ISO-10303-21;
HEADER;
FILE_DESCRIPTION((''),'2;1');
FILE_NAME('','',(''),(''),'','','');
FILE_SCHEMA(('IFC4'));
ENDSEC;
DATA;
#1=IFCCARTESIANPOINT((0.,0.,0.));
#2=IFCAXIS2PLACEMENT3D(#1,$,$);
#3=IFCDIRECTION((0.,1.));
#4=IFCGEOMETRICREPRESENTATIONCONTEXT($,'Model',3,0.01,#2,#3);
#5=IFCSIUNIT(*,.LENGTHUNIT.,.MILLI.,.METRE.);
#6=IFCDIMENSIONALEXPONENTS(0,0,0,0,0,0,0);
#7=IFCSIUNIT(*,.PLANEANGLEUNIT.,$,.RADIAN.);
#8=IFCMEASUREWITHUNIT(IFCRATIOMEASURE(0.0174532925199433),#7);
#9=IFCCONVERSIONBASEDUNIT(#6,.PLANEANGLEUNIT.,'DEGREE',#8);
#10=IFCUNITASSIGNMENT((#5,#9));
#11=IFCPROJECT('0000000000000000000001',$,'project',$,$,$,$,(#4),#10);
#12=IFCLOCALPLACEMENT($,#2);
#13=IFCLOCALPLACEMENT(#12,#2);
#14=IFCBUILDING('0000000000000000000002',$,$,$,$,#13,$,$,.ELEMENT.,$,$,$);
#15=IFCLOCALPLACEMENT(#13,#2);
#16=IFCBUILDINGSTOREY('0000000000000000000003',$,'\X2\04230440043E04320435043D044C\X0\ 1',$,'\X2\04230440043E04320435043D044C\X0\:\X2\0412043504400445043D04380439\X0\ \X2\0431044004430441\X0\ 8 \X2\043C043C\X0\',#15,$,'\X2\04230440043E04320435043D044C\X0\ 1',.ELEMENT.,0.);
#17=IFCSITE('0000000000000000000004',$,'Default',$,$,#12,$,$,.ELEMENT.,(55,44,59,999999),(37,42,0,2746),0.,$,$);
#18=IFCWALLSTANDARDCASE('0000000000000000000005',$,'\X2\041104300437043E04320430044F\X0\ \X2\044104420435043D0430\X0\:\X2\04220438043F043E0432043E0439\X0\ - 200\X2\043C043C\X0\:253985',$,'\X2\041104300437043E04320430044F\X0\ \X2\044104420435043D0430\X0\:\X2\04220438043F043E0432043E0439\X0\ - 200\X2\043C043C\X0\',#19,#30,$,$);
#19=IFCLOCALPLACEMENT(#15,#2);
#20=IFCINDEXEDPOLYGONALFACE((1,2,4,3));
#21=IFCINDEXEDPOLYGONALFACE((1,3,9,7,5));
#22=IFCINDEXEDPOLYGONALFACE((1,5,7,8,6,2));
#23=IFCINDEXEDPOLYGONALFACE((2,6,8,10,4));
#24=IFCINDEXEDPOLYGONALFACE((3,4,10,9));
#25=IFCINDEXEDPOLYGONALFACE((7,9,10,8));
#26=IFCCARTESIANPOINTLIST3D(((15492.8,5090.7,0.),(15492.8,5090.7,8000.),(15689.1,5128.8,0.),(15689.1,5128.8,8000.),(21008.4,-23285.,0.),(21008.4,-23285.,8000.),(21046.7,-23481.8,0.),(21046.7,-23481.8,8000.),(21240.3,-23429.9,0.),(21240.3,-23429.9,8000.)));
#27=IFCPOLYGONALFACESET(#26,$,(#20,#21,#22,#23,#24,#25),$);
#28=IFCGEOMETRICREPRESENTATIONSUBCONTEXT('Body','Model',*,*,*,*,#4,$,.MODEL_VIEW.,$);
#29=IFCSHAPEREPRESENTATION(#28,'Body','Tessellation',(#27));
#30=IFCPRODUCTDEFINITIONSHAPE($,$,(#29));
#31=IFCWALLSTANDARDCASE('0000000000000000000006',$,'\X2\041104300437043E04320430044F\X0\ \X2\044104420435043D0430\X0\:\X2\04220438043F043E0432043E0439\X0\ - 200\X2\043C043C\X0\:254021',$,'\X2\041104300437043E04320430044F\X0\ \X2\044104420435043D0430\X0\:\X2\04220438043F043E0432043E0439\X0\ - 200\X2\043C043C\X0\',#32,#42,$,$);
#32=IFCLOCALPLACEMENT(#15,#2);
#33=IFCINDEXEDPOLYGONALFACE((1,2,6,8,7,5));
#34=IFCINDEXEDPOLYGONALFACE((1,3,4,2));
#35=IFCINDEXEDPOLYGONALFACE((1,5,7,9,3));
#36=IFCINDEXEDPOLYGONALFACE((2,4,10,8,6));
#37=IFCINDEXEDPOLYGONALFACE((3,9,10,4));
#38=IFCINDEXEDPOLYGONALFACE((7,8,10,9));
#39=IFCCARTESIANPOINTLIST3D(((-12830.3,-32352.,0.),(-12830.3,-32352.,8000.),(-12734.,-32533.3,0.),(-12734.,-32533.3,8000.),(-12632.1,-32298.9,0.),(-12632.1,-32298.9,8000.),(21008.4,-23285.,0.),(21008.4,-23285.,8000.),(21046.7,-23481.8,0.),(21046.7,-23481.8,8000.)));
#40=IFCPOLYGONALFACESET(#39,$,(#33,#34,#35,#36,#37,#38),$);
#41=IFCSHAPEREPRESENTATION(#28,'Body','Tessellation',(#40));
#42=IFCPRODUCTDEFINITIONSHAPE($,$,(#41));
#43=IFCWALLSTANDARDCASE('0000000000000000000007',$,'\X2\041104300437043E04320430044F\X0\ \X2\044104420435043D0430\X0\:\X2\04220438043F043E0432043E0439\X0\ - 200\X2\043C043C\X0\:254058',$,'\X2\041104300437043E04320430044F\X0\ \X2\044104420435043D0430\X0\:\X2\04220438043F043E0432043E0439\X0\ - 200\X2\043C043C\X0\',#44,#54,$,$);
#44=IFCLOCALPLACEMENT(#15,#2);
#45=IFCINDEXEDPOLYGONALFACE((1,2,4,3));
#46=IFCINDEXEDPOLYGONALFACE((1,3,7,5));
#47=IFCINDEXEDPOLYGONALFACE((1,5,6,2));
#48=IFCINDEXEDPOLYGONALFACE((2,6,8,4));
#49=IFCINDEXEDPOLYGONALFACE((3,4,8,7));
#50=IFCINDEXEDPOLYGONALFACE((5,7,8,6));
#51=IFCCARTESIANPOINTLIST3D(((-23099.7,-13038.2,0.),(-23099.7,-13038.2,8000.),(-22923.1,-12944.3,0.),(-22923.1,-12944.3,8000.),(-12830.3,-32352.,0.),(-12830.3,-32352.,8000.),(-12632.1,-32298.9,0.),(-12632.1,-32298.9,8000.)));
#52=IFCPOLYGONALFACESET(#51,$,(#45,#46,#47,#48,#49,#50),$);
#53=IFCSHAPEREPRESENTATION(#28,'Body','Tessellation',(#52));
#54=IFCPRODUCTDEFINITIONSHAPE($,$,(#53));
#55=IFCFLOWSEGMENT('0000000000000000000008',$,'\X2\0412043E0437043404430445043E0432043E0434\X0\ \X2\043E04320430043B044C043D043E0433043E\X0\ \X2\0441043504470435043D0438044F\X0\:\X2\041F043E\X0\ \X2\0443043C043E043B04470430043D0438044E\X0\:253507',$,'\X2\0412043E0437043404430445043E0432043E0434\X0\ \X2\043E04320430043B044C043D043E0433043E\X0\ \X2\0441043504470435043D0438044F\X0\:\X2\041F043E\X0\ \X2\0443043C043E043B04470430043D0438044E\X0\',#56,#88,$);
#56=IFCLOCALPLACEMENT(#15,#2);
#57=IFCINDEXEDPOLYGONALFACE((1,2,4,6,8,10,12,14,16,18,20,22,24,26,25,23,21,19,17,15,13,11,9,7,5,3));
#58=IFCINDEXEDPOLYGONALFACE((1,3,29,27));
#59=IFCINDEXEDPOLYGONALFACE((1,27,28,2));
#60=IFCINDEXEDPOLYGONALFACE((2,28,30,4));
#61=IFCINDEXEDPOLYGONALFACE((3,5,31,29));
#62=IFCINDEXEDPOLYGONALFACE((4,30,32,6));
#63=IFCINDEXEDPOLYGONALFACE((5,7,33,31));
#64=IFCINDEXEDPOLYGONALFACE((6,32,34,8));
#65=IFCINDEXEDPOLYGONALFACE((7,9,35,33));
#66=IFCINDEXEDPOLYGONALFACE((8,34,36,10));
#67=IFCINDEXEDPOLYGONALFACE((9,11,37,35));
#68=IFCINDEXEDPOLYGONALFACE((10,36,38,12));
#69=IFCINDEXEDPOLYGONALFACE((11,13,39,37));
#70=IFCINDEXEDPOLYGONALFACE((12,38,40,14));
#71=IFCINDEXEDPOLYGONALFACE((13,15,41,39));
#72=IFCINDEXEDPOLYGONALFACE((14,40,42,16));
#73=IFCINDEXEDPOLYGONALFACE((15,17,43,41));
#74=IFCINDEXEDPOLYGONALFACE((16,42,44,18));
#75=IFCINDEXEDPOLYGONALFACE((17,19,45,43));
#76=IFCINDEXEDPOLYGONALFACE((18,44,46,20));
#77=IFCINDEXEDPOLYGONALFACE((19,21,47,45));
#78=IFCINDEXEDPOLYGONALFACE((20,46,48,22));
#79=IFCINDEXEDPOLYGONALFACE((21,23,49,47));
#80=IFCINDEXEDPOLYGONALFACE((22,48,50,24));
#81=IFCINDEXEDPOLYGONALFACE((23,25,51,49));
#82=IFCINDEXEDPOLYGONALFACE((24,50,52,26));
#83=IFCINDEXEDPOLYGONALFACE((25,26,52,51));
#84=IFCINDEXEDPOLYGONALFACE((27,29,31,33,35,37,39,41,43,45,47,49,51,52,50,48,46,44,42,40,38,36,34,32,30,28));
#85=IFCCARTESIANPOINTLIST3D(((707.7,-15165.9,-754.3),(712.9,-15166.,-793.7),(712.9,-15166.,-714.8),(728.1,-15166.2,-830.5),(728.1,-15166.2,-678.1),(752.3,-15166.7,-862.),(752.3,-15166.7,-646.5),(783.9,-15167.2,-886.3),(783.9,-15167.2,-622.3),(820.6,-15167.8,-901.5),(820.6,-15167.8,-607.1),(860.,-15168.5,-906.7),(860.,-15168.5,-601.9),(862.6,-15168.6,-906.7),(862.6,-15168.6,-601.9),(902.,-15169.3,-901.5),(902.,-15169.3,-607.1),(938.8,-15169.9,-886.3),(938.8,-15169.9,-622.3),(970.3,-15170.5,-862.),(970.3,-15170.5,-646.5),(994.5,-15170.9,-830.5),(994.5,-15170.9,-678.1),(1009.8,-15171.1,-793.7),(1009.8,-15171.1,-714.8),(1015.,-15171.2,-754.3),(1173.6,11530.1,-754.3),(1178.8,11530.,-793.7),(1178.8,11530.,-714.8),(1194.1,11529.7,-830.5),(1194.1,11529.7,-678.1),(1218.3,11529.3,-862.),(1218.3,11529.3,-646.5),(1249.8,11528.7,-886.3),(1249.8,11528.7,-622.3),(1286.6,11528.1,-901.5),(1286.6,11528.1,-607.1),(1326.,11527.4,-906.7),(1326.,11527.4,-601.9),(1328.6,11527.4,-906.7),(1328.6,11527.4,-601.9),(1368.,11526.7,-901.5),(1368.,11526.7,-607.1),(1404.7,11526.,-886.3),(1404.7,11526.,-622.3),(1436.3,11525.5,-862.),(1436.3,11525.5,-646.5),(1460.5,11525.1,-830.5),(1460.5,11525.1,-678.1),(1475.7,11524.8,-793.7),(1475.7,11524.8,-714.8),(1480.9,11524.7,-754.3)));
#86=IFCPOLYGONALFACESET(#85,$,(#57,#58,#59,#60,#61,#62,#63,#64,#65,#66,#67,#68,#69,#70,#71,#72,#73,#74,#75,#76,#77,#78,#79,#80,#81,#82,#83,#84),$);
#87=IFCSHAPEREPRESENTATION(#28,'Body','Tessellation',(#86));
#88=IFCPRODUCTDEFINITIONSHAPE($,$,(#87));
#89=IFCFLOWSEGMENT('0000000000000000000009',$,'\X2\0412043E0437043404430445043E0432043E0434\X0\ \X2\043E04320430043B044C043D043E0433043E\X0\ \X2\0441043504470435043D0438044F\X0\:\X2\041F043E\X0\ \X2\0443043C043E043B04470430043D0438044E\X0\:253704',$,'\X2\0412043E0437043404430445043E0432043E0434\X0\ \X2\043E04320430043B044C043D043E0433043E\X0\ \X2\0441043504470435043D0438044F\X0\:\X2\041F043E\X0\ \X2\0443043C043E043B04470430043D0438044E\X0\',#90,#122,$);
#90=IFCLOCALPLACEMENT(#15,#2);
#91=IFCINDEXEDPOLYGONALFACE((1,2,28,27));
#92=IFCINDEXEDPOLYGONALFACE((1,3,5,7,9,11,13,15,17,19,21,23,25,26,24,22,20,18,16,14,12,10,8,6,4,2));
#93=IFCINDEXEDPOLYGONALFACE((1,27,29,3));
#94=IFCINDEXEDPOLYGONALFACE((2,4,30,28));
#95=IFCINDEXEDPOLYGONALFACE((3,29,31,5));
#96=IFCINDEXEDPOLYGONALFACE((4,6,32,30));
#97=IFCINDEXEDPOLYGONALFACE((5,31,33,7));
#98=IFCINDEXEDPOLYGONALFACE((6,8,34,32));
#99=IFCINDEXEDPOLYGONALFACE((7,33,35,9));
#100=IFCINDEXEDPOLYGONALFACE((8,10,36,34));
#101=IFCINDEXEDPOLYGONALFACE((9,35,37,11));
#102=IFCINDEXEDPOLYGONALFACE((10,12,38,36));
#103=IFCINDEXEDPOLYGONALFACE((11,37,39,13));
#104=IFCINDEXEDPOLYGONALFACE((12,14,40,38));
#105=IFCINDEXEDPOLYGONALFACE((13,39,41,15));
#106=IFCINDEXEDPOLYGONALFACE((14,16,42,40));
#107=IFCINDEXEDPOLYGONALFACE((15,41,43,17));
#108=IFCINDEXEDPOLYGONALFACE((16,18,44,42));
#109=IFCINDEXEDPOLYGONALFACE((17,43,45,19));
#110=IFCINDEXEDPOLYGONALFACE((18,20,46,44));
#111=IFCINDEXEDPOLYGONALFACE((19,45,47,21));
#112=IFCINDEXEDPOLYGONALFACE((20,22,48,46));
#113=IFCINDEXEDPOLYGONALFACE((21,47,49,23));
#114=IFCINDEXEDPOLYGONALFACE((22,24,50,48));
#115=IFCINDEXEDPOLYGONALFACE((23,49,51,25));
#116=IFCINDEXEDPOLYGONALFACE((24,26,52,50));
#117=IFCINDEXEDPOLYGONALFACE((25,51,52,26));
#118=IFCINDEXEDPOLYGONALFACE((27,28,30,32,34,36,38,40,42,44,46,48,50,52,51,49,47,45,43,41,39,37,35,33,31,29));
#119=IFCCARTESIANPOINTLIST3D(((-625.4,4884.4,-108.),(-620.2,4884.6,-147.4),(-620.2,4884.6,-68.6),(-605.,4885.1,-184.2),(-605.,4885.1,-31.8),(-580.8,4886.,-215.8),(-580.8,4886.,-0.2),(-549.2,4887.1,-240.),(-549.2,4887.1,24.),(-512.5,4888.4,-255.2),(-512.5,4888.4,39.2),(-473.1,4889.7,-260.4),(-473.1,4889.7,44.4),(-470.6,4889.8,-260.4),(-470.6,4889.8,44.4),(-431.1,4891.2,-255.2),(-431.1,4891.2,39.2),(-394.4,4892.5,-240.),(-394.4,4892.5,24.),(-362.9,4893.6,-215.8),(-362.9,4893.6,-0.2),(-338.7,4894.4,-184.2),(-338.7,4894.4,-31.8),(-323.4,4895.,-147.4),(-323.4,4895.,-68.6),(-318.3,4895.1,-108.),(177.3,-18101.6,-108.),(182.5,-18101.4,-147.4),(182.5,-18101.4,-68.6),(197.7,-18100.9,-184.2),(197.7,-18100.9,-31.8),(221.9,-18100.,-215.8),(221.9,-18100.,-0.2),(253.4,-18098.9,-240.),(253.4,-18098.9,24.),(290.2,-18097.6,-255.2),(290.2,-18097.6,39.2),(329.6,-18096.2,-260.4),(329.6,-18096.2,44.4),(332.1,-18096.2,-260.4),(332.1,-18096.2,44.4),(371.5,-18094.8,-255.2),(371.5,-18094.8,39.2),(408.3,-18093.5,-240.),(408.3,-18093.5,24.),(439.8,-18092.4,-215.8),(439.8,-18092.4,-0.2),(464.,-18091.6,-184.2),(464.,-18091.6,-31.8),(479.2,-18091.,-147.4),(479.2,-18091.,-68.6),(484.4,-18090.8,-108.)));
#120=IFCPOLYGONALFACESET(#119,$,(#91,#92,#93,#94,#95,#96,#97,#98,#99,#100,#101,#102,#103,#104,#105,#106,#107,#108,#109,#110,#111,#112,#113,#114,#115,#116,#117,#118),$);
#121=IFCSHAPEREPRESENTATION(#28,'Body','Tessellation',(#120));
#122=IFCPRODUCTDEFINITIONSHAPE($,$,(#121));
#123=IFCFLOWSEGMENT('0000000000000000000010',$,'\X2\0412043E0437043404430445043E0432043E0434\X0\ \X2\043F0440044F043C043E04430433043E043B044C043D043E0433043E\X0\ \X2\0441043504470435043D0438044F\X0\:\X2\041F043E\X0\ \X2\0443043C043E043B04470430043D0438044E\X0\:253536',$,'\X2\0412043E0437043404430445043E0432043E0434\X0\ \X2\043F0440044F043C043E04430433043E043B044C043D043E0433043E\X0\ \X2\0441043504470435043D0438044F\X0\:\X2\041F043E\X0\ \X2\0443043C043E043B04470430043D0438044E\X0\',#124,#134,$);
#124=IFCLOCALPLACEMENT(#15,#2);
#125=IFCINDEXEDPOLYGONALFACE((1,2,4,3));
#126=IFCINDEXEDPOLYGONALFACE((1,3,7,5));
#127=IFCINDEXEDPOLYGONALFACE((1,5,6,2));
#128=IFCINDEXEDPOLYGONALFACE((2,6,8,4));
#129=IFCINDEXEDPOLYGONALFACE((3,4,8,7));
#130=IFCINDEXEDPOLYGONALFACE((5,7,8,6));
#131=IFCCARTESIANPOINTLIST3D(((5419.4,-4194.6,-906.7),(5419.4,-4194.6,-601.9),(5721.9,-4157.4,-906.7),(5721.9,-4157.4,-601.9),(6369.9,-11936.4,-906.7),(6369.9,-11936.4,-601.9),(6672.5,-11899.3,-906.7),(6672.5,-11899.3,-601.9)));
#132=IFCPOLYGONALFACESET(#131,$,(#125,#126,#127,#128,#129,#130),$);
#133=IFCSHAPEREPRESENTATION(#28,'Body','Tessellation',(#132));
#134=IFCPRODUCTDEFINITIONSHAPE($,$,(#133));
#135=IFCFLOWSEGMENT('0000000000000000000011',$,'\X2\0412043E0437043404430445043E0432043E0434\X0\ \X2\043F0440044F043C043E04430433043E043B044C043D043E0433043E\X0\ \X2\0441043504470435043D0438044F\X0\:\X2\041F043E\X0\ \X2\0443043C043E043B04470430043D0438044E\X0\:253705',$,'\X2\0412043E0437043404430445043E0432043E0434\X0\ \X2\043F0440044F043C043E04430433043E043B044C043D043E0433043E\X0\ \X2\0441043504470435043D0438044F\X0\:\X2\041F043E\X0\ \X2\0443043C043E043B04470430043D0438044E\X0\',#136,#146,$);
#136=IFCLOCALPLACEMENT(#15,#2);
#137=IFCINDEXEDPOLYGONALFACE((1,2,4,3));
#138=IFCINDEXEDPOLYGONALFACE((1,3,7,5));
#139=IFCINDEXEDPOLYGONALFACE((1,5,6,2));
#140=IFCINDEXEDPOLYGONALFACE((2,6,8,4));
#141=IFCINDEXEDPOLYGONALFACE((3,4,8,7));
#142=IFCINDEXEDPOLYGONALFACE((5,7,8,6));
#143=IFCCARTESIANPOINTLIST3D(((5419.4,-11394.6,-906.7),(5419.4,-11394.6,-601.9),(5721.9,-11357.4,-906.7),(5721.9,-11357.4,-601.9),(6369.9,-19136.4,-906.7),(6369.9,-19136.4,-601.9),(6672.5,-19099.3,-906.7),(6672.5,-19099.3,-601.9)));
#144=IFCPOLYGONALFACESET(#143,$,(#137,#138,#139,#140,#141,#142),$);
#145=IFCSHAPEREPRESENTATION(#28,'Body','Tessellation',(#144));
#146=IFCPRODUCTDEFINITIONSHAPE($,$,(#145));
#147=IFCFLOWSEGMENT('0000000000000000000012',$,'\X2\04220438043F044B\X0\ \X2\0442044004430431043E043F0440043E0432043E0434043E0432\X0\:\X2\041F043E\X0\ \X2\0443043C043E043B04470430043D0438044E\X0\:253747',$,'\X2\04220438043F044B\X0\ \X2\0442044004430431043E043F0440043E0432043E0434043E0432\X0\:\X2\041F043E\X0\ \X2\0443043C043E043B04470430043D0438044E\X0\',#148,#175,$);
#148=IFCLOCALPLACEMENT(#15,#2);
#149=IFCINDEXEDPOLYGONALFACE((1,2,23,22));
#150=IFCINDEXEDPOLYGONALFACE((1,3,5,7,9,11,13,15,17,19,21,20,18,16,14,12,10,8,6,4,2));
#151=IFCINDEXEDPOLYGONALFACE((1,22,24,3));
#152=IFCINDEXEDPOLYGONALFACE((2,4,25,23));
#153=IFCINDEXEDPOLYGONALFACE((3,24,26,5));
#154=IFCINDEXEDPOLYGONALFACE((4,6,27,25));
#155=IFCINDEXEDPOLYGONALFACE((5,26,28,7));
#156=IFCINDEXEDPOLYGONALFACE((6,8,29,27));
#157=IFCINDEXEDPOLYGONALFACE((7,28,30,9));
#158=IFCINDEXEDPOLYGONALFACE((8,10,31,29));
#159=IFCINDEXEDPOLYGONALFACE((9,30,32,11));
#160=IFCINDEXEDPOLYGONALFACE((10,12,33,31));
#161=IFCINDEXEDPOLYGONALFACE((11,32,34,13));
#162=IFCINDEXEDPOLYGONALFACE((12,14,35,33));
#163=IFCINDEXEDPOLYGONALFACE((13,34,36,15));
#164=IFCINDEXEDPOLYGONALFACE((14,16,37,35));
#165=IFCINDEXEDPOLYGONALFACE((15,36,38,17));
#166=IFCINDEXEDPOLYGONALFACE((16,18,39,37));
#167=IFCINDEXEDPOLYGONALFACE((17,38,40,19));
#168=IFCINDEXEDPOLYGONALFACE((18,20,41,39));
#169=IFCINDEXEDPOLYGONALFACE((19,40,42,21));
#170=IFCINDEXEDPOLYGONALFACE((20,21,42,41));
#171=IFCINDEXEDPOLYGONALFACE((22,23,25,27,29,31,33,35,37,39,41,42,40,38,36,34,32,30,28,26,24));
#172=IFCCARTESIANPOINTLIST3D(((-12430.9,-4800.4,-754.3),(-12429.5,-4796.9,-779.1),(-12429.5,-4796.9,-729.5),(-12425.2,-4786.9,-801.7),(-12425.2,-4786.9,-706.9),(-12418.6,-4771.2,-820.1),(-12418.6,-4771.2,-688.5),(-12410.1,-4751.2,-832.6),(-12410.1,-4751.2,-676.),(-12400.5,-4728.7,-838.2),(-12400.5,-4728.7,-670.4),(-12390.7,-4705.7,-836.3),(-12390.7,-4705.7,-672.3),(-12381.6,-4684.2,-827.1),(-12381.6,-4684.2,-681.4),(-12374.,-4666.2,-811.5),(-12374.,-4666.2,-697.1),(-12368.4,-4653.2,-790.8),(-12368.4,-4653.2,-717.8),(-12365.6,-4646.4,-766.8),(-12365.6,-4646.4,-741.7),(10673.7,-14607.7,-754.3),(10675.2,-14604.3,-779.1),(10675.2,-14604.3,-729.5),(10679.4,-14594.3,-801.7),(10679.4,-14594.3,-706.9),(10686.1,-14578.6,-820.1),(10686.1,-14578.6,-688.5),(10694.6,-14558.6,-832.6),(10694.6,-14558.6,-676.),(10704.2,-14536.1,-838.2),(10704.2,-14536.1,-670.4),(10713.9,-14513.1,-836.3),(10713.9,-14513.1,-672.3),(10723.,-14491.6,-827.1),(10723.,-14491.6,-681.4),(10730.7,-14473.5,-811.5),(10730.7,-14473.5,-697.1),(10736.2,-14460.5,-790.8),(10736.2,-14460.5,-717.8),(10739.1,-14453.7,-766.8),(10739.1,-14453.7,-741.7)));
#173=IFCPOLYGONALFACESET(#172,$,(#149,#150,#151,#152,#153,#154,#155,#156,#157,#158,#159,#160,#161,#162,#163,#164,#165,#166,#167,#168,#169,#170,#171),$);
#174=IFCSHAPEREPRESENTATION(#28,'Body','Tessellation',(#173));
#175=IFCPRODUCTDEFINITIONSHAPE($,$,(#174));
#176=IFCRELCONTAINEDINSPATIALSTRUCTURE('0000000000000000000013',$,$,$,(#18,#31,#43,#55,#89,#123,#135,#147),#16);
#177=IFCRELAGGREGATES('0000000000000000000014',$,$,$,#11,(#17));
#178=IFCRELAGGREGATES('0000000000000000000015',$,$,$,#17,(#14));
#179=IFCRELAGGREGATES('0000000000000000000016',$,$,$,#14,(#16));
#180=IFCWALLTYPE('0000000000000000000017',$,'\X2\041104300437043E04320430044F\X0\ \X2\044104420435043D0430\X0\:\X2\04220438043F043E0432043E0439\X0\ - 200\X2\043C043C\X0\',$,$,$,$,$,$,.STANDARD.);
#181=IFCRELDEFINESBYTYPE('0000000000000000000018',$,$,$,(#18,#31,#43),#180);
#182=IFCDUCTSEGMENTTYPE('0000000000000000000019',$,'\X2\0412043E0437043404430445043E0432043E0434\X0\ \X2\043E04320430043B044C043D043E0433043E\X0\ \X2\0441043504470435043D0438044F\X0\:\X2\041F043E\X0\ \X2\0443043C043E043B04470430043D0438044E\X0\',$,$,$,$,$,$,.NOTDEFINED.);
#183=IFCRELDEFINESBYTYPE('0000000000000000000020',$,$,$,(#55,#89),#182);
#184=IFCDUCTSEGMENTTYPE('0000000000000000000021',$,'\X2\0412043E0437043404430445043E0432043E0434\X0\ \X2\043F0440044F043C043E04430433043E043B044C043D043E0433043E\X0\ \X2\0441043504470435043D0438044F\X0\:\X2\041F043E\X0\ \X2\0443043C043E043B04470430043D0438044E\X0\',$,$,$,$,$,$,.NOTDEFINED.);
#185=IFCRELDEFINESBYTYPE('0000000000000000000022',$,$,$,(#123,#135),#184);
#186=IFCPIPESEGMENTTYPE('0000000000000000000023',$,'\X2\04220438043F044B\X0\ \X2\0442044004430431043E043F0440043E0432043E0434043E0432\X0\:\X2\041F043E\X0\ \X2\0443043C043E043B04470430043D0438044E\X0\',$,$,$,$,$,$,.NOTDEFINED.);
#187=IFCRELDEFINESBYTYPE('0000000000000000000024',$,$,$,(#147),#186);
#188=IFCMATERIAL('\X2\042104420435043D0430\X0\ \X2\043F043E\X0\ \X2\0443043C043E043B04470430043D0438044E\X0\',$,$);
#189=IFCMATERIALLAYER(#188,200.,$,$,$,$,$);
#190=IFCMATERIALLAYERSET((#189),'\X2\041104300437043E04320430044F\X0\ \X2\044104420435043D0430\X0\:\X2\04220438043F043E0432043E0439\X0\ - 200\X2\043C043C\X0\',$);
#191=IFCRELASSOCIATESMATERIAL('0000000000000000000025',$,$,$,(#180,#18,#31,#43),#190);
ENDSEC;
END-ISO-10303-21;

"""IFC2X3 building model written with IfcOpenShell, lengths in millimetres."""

from ifc_helpers import new_model, entity, si_unit, converted_unit, direction, frame, frame_2d, origin, origin_2d_with_axis, place, context, subcontext, project, spatial, polyline, circle_curve, parameter, trimmed, segment, composite_curve, rectangle, circle, outline, extrude, material, layer, layer_set, layer_usage, type_object, element, save


model = new_model("IFC2X3")

# Units and contexts
model_context = context("Model", 3, precision=0.01, world=origin(), true_north=direction((0.0, 1.0)))
body_context = subcontext(model_context, "Body", "Model", "MODEL_VIEW")
ifc_project = project(units=[si_unit("LENGTHUNIT", "METRE", prefix="MILLI"), converted_unit("PLANEANGLEUNIT", "DEGREE", entity("IfcRatioMeasure", 0.0174532925199433), si_unit("PLANEANGLEUNIT", "RADIAN"), dimensions=[0, 0, 0, 0, 0, 0, 0])], contexts=[model_context])

# Site, building, storey
site_placement = place(None, origin())
site = spatial("IfcSite", under=ifc_project, at=site_placement, Name="Default", CompositionType="ELEMENT", RefLatitude=(55, 44, 59, 999999), RefLongitude=(37, 42, 0, 2746), RefElevation=0.0)
building_placement = place(site_placement, origin())
building = spatial("IfcBuilding", under=site, at=building_placement, CompositionType="ELEMENT")
storey_placement = place(building_placement, origin())
storey = spatial("IfcBuildingStorey", under=building, at=storey_placement, Name="Уровень 1", ObjectType="Уровень:Верхний брус 8 мм", LongName="Уровень 1", CompositionType="ELEMENT", Elevation=0.0)

# Walls
ifc_material = material(Name="Стена по умолчанию")
ifc_layer = layer(ifc_material, 200.0)
ifc_layer_set = layer_set([ifc_layer], Name="Базовая стена:Типовой - 200мм")
ifc_layer_usage_1 = layer_usage(ifc_layer_set, "AXIS2", "NEGATIVE", 100.0)
wall_type = type_object("IfcWallType", Name="Базовая стена:Типовой - 200мм", PredefinedType="STANDARD", material=ifc_layer_set)
wall_1_placement = place(storey_placement, frame((15590.9, 5109.8, 0.0), z_axis=(0.0, 0.0, 1.0), x_axis=(0.190809, -0.981627, 0.0)))
element("IfcWallStandardCase", 1, at=wall_1_placement, inside=storey, type_object=wall_type, material=ifc_layer_usage_1, Name="Базовая стена:Типовой - 200мм:253985", ObjectType="Базовая стена:Типовой - 200мм", context=body_context, shape_type="SweptSolid", body=[
    extrude(outline(polyline([(29107.2, -100.0), (29093.3, 100.0), (0.0, 100.0), (0.0, -100.0), (28906.7, -100.0), (29107.2, -100.0)])), origin(), (0.0, 0.0, 1.0), 8000.0),
])
ifc_layer_usage_2 = layer_usage(ifc_layer_set, "AXIS2", "NEGATIVE", 100.0)
wall_2_placement = place(storey_placement, frame((21034.3, -23381.6, 0.0), z_axis=(0.0, 0.0, 1.0), x_axis=(-0.965926, -0.258819, 0.0)))
element("IfcWallStandardCase", 2, at=wall_2_placement, inside=storey, type_object=wall_type, material=ifc_layer_usage_2, Name="Базовая стена:Типовой - 200мм:254021", ObjectType="Базовая стена:Типовой - 200мм", context=body_context, shape_type="SweptSolid", body=[
    extrude(outline(polyline([(35032.5, -100.0), (34986.3, 100.0), (14.0, 100.0), (0.0, -100.0), (34827.2, -100.0), (35032.5, -100.0)])), origin(), (0.0, 0.0, 1.0), 8000.0),
])
ifc_layer_usage_3 = layer_usage(ifc_layer_set, "AXIS2", "NEGATIVE", 100.0)
wall_3_placement = place(storey_placement, frame((-12720.4, -32345.9, 0.0), z_axis=(0.0, 0.0, 1.0), x_axis=(-0.469472, 0.882948, 0.0)))
element("IfcWallStandardCase", 3, at=wall_3_placement, inside=storey, type_object=wall_type, material=ifc_layer_usage_3, Name="Базовая стена:Типовой - 200мм:254058", ObjectType="Базовая стена:Типовой - 200мм", context=body_context, shape_type="SweptSolid", body=[
    extrude(outline(polyline([(21920.5, -100.0), (21920.5, 100.0), (46.2, 100.0), (0.0, -100.0), (21920.5, -100.0)])), origin(), (0.0, 0.0, 1.0), 8000.0),
])

# Flow segments
duct_segment_type_1 = type_object("IfcDuctSegmentType", Name="Воздуховод овального сечения:По умолчанию", PredefinedType="NOTDEFINED")
flow_segment_1_placement = place(storey_placement, origin())
element("IfcFlowSegment", 4, at=flow_segment_1_placement, inside=storey, type_object=duct_segment_type_1, Name="Воздуховод овального сечения:По умолчанию:253507", ObjectType="Воздуховод овального сечения:По умолчанию", context=body_context, shape_type="SweptSolid", body=[
    extrude(outline(composite_curve([segment(polyline([(-1.3, -152.4), (1.3, -152.4)]), True, "CONTINUOUS"), segment(trimmed(circle_curve(frame_2d((1.3, 0.0), x_axis=(-1.0, 0.0)), 152.4), [parameter(90.0)], [parameter(180.0)], True, "PARAMETER"), True, "CONTINUOUS"), segment(trimmed(circle_curve(frame_2d((1.3, 0.0), x_axis=(-1.0, 0.0)), 152.4), [parameter(180.0)], [parameter(270.0)], True, "PARAMETER"), True, "CONTINUOUS"), segment(polyline([(1.3, 152.4), (-1.3, 152.4)]), True, "CONTINUOUS"), segment(trimmed(circle_curve(frame_2d((-1.3, 0.0), x_axis=(-1.0, 0.0)), 152.4), [parameter(270.0)], [parameter(0.0)], True, "PARAMETER"), True, "CONTINUOUS"), segment(trimmed(circle_curve(frame_2d((-1.3, 0.0), x_axis=(-1.0, 0.0)), 152.4), [parameter(0.0)], [parameter(90.0)], True, "PARAMETER"), True, "CONTINUOUS")], self_intersect=False)), frame((861.3, -15168.6, -754.3), z_axis=(0.017452, 0.999848, 0.0), x_axis=(0.999848, -0.017452, 0.0)), (0.0, 0.0, 1.0), 26700.0),
])
flow_segment_2_placement = place(storey_placement, origin())
element("IfcFlowSegment", 5, at=flow_segment_2_placement, inside=storey, type_object=duct_segment_type_1, Name="Воздуховод овального сечения:По умолчанию:253704", ObjectType="Воздуховод овального сечения:По умолчанию", context=body_context, shape_type="SweptSolid", body=[
    extrude(outline(composite_curve([segment(polyline([(-1.3, -152.4), (1.3, -152.4)]), True, "CONTINUOUS"), segment(trimmed(circle_curve(frame_2d((1.3, 0.0), x_axis=(-1.0, 0.0)), 152.4), [parameter(90.0)], [parameter(180.0)], True, "PARAMETER"), True, "CONTINUOUS"), segment(trimmed(circle_curve(frame_2d((1.3, 0.0), x_axis=(-1.0, 0.0)), 152.4), [parameter(180.0)], [parameter(270.0)], True, "PARAMETER"), True, "CONTINUOUS"), segment(polyline([(1.3, 152.4), (-1.3, 152.4)]), True, "CONTINUOUS"), segment(trimmed(circle_curve(frame_2d((-1.3, 0.0), x_axis=(-1.0, 0.0)), 152.4), [parameter(270.0)], [parameter(0.0)], True, "PARAMETER"), True, "CONTINUOUS"), segment(trimmed(circle_curve(frame_2d((-1.3, 0.0), x_axis=(-1.0, 0.0)), 152.4), [parameter(0.0)], [parameter(90.0)], True, "PARAMETER"), True, "CONTINUOUS")], self_intersect=False)), frame((330.9, -18096.2, -108.0), z_axis=(-0.034899, 0.999391, 0.0), x_axis=(0.999391, 0.034899, 0.0)), (0.0, 0.0, 1.0), 23000.0),
])
duct_segment_type_2 = type_object("IfcDuctSegmentType", Name="Воздуховод прямоугольного сечения:По умолчанию", PredefinedType="NOTDEFINED")
flow_segment_3_placement = place(storey_placement, origin())
element("IfcFlowSegment", 6, at=flow_segment_3_placement, inside=storey, type_object=duct_segment_type_2, Name="Воздуховод прямоугольного сечения:По умолчанию:253536", ObjectType="Воздуховод прямоугольного сечения:По умолчанию", context=body_context, shape_type="SweptSolid", body=[
    extrude(rectangle(XDim=7800.0, YDim=304.8, at=frame_2d((0.0, 0.0), x_axis=(1.0, 0.0))), frame((6045.9, -8046.9, -906.7), z_axis=(0.0, 0.0, 1.0), x_axis=(-0.121869, 0.992546, 0.0)), (0.0, 0.0, 1.0), 304.8),
])
flow_segment_4_placement = place(storey_placement, origin())
element("IfcFlowSegment", 7, at=flow_segment_4_placement, inside=storey, type_object=duct_segment_type_2, Name="Воздуховод прямоугольного сечения:По умолчанию:253705", ObjectType="Воздуховод прямоугольного сечения:По умолчанию", context=body_context, shape_type="SweptSolid", body=[
    extrude(rectangle(XDim=7800.0, YDim=304.8, at=origin_2d_with_axis()), frame((6045.9, -15246.9, -906.7), z_axis=(0.0, 0.0, 1.0), x_axis=(-0.121869, 0.992546, 0.0)), (0.0, 0.0, 1.0), 304.8),
])
pipe_segment_type = type_object("IfcPipeSegmentType", Name="Типы трубопроводов:По умолчанию", PredefinedType="NOTDEFINED")
flow_segment_5_placement = place(storey_placement, origin())
element("IfcFlowSegment", 8, at=flow_segment_5_placement, inside=storey, type_object=pipe_segment_type, Name="Типы трубопроводов:По умолчанию:253747", ObjectType="Типы трубопроводов:По умолчанию", context=body_context, shape_type="SweptSolid", body=[
    extrude(circle(Radius=84.1, at=origin_2d_with_axis()), frame((-12398.1, -4722.9, -754.3), z_axis=(0.920505, -0.390731, 0.0), x_axis=(-0.390731, -0.920505, 0.0)), (0.0, 0.0, 1.0), 25100.0),
])

save(model, "model.ifc")
